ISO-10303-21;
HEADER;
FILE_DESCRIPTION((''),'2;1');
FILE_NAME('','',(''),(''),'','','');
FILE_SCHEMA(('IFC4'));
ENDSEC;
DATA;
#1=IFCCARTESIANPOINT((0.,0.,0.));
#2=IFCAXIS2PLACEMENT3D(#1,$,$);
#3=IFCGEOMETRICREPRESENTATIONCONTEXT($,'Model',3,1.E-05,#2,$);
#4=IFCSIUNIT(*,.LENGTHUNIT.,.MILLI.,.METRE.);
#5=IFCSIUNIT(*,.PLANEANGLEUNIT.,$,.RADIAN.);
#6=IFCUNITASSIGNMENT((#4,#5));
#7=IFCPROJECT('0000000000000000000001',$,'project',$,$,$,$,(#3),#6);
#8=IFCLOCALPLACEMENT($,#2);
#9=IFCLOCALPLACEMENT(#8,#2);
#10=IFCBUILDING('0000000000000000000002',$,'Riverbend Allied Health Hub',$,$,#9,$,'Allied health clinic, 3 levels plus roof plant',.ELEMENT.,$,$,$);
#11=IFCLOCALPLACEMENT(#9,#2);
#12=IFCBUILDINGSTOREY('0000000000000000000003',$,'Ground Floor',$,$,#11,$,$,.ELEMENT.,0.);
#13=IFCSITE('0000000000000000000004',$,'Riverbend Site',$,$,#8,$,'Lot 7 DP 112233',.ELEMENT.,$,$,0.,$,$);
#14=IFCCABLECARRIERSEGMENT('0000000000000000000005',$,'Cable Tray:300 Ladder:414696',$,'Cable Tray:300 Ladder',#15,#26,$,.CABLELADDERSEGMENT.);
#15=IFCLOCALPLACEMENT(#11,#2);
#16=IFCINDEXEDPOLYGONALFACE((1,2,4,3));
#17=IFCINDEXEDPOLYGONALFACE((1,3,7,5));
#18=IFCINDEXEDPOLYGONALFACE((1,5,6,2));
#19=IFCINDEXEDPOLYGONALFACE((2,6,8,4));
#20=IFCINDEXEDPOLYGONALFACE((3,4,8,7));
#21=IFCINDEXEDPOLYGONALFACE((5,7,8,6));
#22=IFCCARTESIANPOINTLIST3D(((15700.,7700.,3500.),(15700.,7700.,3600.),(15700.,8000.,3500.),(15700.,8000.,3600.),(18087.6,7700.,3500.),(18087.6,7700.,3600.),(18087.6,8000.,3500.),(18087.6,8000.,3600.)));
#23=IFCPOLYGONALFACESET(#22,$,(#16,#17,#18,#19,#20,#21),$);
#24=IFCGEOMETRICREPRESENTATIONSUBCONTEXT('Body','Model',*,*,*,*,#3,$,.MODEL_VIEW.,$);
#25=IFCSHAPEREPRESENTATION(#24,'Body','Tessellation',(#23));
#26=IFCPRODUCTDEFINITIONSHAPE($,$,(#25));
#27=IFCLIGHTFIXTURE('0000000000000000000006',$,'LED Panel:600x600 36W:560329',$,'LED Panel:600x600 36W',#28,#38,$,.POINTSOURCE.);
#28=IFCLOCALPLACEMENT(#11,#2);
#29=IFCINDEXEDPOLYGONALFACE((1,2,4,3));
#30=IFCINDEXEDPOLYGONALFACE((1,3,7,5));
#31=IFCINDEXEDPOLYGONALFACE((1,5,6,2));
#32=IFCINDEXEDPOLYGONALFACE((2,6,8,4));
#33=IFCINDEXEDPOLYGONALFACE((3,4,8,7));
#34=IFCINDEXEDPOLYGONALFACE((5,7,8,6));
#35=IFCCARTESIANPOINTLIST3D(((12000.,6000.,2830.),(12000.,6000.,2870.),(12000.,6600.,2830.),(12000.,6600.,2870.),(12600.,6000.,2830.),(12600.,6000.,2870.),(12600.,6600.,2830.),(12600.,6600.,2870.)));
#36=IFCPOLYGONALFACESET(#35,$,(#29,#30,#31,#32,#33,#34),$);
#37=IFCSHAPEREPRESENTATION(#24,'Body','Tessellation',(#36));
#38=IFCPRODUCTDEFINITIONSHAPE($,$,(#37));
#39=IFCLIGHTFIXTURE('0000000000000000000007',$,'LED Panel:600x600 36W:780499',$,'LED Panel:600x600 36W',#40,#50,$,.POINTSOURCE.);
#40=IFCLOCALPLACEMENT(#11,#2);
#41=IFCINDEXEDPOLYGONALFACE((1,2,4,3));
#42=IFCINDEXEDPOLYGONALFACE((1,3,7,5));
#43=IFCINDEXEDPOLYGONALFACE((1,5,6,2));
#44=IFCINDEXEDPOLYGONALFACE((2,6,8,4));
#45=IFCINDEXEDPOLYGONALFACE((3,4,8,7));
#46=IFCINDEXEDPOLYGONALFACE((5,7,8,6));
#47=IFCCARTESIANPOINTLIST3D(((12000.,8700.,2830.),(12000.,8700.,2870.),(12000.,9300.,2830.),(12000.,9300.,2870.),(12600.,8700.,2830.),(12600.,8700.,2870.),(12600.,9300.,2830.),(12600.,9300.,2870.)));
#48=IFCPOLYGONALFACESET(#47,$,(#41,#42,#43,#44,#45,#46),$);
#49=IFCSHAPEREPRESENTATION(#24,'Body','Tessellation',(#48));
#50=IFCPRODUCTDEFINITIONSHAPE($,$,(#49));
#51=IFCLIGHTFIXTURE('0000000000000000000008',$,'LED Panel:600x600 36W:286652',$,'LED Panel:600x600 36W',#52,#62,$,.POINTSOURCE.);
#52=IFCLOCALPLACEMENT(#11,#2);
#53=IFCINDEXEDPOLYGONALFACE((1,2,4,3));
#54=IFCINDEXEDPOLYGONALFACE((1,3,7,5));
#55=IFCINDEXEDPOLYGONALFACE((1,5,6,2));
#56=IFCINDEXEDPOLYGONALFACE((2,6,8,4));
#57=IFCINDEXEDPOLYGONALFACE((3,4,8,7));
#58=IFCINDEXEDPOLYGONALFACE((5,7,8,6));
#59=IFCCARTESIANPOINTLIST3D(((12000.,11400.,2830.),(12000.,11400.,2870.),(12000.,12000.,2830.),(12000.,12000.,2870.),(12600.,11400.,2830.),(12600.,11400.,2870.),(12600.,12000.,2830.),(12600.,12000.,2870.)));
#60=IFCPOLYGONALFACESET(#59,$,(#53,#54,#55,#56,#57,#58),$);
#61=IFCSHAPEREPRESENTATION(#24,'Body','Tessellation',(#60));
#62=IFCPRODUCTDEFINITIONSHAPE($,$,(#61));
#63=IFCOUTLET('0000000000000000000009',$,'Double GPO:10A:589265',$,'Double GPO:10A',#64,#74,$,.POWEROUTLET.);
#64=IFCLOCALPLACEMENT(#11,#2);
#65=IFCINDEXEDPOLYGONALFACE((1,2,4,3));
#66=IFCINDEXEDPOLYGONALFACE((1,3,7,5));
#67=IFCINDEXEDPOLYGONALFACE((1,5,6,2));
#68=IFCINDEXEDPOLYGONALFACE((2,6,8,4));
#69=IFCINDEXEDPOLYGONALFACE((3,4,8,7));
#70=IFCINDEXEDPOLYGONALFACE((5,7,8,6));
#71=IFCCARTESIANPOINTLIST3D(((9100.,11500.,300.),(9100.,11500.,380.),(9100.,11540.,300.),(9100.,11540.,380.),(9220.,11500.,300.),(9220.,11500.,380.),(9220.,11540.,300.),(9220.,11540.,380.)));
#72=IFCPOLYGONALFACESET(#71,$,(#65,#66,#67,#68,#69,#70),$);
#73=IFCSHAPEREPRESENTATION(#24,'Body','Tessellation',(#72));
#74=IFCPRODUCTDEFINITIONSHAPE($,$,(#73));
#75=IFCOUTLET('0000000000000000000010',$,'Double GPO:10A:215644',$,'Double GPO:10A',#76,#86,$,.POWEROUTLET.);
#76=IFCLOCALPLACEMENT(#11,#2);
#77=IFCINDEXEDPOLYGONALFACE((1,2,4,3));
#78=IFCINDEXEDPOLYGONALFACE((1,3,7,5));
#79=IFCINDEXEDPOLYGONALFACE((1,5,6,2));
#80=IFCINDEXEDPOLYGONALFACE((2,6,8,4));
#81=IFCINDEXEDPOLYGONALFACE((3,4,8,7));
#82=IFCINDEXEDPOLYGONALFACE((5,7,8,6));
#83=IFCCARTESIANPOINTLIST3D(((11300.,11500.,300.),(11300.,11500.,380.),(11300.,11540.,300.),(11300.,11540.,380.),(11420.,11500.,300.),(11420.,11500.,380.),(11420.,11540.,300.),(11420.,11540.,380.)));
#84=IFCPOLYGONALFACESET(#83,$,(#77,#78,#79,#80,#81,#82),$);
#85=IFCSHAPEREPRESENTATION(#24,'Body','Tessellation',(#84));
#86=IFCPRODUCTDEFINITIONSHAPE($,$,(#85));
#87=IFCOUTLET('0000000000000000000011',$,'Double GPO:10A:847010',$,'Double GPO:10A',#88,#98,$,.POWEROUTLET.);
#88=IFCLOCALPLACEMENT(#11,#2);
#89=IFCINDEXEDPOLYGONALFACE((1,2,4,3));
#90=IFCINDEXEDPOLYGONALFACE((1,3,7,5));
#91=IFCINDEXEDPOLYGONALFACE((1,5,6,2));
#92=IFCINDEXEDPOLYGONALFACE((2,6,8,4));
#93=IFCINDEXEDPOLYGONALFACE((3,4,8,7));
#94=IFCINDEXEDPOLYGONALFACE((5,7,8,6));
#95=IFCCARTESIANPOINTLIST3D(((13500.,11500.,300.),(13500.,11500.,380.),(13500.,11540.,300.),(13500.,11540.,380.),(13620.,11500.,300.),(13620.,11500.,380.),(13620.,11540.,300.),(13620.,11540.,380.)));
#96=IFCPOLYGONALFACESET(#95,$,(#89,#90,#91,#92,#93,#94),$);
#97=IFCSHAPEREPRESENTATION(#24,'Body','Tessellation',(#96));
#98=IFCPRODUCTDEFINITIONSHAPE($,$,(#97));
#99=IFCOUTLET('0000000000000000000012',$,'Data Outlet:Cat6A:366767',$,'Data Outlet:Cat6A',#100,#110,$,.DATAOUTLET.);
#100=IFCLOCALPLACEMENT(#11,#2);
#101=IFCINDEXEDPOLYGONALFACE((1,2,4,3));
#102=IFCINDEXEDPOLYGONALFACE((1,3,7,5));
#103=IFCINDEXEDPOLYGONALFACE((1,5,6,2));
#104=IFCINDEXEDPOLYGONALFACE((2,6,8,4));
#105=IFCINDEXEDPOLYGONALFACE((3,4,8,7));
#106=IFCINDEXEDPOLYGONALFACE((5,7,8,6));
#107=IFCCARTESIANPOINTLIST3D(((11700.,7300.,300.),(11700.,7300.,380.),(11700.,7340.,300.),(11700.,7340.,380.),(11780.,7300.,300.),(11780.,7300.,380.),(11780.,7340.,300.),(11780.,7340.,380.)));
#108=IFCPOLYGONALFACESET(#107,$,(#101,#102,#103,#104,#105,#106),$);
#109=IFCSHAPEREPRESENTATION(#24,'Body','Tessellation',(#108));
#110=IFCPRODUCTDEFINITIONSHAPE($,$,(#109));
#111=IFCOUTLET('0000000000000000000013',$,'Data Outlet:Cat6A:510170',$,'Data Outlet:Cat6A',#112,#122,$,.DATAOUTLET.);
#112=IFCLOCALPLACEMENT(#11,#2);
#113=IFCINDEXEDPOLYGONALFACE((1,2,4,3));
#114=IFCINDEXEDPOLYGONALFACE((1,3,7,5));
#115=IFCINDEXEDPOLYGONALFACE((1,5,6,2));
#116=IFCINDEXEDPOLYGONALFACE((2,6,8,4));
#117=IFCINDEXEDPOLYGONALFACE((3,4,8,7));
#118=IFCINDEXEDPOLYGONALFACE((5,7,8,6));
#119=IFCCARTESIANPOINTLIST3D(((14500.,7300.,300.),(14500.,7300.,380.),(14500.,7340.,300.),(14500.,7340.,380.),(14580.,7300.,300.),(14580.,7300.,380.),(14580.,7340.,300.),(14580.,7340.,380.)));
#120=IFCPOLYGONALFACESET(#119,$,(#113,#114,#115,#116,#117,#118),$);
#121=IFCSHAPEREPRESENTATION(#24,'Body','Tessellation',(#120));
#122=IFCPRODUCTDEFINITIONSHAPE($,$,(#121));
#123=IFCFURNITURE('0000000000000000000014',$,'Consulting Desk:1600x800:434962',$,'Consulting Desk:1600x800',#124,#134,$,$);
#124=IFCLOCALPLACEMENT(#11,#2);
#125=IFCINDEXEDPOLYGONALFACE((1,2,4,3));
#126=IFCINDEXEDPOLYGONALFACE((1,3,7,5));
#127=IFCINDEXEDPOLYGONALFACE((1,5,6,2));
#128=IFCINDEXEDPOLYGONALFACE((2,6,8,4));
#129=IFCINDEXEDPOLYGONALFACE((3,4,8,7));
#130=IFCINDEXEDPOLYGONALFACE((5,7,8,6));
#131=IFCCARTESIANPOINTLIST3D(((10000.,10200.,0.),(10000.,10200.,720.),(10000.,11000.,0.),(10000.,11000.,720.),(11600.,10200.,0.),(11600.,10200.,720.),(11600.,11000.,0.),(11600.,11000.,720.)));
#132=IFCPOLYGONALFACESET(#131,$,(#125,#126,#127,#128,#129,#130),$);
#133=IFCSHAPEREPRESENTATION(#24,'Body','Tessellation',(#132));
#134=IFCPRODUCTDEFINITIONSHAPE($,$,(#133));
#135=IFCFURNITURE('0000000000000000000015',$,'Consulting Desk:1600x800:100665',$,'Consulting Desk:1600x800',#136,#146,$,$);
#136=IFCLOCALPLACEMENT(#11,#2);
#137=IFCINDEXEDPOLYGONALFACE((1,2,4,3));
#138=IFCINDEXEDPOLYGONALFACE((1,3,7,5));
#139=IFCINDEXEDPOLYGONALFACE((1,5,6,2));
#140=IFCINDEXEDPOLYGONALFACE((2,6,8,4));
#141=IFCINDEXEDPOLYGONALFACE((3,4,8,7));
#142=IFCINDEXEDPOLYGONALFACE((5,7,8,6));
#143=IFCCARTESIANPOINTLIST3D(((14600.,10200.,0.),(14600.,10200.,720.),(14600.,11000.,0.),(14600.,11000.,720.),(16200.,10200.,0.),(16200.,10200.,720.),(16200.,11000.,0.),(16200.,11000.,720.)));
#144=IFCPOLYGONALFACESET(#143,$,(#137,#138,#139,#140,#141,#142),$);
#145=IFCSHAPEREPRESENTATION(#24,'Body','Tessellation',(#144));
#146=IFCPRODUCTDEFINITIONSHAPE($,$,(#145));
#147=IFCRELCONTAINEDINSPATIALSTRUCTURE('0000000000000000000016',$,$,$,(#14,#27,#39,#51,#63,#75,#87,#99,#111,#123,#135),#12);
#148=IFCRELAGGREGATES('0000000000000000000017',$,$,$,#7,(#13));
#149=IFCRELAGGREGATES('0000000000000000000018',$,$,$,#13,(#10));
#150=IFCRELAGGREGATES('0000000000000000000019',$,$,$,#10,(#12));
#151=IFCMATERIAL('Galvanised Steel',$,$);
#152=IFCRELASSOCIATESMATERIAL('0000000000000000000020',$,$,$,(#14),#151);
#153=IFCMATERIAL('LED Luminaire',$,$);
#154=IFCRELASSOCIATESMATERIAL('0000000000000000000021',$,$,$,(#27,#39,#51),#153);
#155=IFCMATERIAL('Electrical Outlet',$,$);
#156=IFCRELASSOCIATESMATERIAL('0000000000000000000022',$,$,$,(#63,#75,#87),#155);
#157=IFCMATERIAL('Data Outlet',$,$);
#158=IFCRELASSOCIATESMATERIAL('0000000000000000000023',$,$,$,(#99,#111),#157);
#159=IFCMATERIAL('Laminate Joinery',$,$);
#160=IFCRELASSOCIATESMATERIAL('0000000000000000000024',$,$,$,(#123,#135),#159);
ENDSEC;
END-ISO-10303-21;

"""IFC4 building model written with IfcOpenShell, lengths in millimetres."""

from ifc_helpers import new_model, si_unit, frame, frame_2d, origin, place, context, subcontext, project, spatial, rectangle, extrude, material, element, save


model = new_model("IFC4")

# Units and contexts
model_context = context("Model", 3, precision=1e-05, world=origin())
body_context = subcontext(model_context, "Body", "Model", "MODEL_VIEW")
ifc_project = project(units=[si_unit("LENGTHUNIT", "METRE", prefix="MILLI"), si_unit("PLANEANGLEUNIT", "RADIAN")], contexts=[model_context])

# Site, building, storey
site_placement = place(None, origin())
site = spatial("IfcSite", under=ifc_project, at=site_placement, Name="Riverbend Site", LongName="Lot 7 DP 112233", CompositionType="ELEMENT", RefElevation=0.0)
building_placement = place(site_placement, origin())
building = spatial("IfcBuilding", under=site, at=building_placement, Name="Riverbend Allied Health Hub", LongName="Allied health clinic, 3 levels plus roof plant", CompositionType="ELEMENT")
storey_placement = place(building_placement, origin())
storey = spatial("IfcBuildingStorey", under=building, at=storey_placement, Name="Ground Floor", CompositionType="ELEMENT", Elevation=0.0)

# Shared definitions
ifc_material_1 = material(Name="Galvanised Steel")

# Cable carrier segment
cable_carrier_segment_1_placement = place(storey_placement, frame((15700.0, 7700.0, 3500.0)))
element("IfcCableCarrierSegment", 1, at=cable_carrier_segment_1_placement, inside=storey, material=ifc_material_1, Name="Cable Tray:300 Ladder:414696", ObjectType="Cable Tray:300 Ladder", PredefinedType="CABLELADDERSEGMENT", context=body_context, shape_type="SweptSolid", body=[
    extrude(rectangle(XDim=2387.6, YDim=300.0, at=frame_2d((1193.8, 150.0))), origin(), (0.0, 0.0, 1.0), 100.0),
])

# Light fixtures
ifc_material_2 = material(Name="LED Luminaire")
for number, where, name in (
    (2, (12000.0, 6000.0, 2830.0), "LED Panel:600x600 36W:560329"),
    (3, (12000.0, 8700.0, 2830.0), "LED Panel:600x600 36W:780499"),
    (4, (12000.0, 11400.0, 2830.0), "LED Panel:600x600 36W:286652"),
):
    element("IfcLightFixture", number, at=place(storey_placement, frame(where)), inside=storey, material=ifc_material_2, Name=name, ObjectType="LED Panel:600x600 36W", PredefinedType="POINTSOURCE", context=body_context, shape_type="SweptSolid", body=[
        extrude(rectangle(XDim=600.0, YDim=600.0, at=frame_2d((300.0, 300.0))), origin(), (0.0, 0.0, 1.0), 40.0),
    ])

# Outlets
ifc_material_3 = material(Name="Electrical Outlet")
for number, where, name in (
    (5, (9100.0, 11500.0, 300.0), "Double GPO:10A:589265"),
    (6, (11300.0, 11500.0, 300.0), "Double GPO:10A:215644"),
    (7, (13500.0, 11500.0, 300.0), "Double GPO:10A:847010"),
):
    element("IfcOutlet", number, at=place(storey_placement, frame(where)), inside=storey, material=ifc_material_3, Name=name, ObjectType="Double GPO:10A", PredefinedType="POWEROUTLET", context=body_context, shape_type="SweptSolid", body=[
        extrude(rectangle(XDim=120.0, YDim=40.0, at=frame_2d((60.0, 20.0))), origin(), (0.0, 0.0, 1.0), 80.0),
    ])
ifc_material_4 = material(Name="Data Outlet")
for number, where, name in (
    (8, (11700.0, 7300.0, 300.0), "Data Outlet:Cat6A:366767"),
    (9, (14500.0, 7300.0, 300.0), "Data Outlet:Cat6A:510170"),
):
    element("IfcOutlet", number, at=place(storey_placement, frame(where)), inside=storey, material=ifc_material_4, Name=name, ObjectType="Data Outlet:Cat6A", PredefinedType="DATAOUTLET", context=body_context, shape_type="SweptSolid", body=[
        extrude(rectangle(XDim=80.0, YDim=40.0, at=frame_2d((40.0, 20.0))), origin(), (0.0, 0.0, 1.0), 80.0),
    ])

# Furniture
ifc_material_5 = material(Name="Laminate Joinery")
for number, where, name in (
    (10, (10000.0, 10200.0, 0.0), "Consulting Desk:1600x800:434962"),
    (11, (14600.0, 10200.0, 0.0), "Consulting Desk:1600x800:100665"),
):
    element("IfcFurniture", number, at=place(storey_placement, frame(where)), inside=storey, material=ifc_material_5, Name=name, ObjectType="Consulting Desk:1600x800", context=body_context, shape_type="SweptSolid", body=[
        extrude(rectangle(XDim=1600.0, YDim=800.0, at=frame_2d((800.0, 400.0))), origin(), (0.0, 0.0, 1.0), 720.0),
    ])

save(model, "model.ifc")
